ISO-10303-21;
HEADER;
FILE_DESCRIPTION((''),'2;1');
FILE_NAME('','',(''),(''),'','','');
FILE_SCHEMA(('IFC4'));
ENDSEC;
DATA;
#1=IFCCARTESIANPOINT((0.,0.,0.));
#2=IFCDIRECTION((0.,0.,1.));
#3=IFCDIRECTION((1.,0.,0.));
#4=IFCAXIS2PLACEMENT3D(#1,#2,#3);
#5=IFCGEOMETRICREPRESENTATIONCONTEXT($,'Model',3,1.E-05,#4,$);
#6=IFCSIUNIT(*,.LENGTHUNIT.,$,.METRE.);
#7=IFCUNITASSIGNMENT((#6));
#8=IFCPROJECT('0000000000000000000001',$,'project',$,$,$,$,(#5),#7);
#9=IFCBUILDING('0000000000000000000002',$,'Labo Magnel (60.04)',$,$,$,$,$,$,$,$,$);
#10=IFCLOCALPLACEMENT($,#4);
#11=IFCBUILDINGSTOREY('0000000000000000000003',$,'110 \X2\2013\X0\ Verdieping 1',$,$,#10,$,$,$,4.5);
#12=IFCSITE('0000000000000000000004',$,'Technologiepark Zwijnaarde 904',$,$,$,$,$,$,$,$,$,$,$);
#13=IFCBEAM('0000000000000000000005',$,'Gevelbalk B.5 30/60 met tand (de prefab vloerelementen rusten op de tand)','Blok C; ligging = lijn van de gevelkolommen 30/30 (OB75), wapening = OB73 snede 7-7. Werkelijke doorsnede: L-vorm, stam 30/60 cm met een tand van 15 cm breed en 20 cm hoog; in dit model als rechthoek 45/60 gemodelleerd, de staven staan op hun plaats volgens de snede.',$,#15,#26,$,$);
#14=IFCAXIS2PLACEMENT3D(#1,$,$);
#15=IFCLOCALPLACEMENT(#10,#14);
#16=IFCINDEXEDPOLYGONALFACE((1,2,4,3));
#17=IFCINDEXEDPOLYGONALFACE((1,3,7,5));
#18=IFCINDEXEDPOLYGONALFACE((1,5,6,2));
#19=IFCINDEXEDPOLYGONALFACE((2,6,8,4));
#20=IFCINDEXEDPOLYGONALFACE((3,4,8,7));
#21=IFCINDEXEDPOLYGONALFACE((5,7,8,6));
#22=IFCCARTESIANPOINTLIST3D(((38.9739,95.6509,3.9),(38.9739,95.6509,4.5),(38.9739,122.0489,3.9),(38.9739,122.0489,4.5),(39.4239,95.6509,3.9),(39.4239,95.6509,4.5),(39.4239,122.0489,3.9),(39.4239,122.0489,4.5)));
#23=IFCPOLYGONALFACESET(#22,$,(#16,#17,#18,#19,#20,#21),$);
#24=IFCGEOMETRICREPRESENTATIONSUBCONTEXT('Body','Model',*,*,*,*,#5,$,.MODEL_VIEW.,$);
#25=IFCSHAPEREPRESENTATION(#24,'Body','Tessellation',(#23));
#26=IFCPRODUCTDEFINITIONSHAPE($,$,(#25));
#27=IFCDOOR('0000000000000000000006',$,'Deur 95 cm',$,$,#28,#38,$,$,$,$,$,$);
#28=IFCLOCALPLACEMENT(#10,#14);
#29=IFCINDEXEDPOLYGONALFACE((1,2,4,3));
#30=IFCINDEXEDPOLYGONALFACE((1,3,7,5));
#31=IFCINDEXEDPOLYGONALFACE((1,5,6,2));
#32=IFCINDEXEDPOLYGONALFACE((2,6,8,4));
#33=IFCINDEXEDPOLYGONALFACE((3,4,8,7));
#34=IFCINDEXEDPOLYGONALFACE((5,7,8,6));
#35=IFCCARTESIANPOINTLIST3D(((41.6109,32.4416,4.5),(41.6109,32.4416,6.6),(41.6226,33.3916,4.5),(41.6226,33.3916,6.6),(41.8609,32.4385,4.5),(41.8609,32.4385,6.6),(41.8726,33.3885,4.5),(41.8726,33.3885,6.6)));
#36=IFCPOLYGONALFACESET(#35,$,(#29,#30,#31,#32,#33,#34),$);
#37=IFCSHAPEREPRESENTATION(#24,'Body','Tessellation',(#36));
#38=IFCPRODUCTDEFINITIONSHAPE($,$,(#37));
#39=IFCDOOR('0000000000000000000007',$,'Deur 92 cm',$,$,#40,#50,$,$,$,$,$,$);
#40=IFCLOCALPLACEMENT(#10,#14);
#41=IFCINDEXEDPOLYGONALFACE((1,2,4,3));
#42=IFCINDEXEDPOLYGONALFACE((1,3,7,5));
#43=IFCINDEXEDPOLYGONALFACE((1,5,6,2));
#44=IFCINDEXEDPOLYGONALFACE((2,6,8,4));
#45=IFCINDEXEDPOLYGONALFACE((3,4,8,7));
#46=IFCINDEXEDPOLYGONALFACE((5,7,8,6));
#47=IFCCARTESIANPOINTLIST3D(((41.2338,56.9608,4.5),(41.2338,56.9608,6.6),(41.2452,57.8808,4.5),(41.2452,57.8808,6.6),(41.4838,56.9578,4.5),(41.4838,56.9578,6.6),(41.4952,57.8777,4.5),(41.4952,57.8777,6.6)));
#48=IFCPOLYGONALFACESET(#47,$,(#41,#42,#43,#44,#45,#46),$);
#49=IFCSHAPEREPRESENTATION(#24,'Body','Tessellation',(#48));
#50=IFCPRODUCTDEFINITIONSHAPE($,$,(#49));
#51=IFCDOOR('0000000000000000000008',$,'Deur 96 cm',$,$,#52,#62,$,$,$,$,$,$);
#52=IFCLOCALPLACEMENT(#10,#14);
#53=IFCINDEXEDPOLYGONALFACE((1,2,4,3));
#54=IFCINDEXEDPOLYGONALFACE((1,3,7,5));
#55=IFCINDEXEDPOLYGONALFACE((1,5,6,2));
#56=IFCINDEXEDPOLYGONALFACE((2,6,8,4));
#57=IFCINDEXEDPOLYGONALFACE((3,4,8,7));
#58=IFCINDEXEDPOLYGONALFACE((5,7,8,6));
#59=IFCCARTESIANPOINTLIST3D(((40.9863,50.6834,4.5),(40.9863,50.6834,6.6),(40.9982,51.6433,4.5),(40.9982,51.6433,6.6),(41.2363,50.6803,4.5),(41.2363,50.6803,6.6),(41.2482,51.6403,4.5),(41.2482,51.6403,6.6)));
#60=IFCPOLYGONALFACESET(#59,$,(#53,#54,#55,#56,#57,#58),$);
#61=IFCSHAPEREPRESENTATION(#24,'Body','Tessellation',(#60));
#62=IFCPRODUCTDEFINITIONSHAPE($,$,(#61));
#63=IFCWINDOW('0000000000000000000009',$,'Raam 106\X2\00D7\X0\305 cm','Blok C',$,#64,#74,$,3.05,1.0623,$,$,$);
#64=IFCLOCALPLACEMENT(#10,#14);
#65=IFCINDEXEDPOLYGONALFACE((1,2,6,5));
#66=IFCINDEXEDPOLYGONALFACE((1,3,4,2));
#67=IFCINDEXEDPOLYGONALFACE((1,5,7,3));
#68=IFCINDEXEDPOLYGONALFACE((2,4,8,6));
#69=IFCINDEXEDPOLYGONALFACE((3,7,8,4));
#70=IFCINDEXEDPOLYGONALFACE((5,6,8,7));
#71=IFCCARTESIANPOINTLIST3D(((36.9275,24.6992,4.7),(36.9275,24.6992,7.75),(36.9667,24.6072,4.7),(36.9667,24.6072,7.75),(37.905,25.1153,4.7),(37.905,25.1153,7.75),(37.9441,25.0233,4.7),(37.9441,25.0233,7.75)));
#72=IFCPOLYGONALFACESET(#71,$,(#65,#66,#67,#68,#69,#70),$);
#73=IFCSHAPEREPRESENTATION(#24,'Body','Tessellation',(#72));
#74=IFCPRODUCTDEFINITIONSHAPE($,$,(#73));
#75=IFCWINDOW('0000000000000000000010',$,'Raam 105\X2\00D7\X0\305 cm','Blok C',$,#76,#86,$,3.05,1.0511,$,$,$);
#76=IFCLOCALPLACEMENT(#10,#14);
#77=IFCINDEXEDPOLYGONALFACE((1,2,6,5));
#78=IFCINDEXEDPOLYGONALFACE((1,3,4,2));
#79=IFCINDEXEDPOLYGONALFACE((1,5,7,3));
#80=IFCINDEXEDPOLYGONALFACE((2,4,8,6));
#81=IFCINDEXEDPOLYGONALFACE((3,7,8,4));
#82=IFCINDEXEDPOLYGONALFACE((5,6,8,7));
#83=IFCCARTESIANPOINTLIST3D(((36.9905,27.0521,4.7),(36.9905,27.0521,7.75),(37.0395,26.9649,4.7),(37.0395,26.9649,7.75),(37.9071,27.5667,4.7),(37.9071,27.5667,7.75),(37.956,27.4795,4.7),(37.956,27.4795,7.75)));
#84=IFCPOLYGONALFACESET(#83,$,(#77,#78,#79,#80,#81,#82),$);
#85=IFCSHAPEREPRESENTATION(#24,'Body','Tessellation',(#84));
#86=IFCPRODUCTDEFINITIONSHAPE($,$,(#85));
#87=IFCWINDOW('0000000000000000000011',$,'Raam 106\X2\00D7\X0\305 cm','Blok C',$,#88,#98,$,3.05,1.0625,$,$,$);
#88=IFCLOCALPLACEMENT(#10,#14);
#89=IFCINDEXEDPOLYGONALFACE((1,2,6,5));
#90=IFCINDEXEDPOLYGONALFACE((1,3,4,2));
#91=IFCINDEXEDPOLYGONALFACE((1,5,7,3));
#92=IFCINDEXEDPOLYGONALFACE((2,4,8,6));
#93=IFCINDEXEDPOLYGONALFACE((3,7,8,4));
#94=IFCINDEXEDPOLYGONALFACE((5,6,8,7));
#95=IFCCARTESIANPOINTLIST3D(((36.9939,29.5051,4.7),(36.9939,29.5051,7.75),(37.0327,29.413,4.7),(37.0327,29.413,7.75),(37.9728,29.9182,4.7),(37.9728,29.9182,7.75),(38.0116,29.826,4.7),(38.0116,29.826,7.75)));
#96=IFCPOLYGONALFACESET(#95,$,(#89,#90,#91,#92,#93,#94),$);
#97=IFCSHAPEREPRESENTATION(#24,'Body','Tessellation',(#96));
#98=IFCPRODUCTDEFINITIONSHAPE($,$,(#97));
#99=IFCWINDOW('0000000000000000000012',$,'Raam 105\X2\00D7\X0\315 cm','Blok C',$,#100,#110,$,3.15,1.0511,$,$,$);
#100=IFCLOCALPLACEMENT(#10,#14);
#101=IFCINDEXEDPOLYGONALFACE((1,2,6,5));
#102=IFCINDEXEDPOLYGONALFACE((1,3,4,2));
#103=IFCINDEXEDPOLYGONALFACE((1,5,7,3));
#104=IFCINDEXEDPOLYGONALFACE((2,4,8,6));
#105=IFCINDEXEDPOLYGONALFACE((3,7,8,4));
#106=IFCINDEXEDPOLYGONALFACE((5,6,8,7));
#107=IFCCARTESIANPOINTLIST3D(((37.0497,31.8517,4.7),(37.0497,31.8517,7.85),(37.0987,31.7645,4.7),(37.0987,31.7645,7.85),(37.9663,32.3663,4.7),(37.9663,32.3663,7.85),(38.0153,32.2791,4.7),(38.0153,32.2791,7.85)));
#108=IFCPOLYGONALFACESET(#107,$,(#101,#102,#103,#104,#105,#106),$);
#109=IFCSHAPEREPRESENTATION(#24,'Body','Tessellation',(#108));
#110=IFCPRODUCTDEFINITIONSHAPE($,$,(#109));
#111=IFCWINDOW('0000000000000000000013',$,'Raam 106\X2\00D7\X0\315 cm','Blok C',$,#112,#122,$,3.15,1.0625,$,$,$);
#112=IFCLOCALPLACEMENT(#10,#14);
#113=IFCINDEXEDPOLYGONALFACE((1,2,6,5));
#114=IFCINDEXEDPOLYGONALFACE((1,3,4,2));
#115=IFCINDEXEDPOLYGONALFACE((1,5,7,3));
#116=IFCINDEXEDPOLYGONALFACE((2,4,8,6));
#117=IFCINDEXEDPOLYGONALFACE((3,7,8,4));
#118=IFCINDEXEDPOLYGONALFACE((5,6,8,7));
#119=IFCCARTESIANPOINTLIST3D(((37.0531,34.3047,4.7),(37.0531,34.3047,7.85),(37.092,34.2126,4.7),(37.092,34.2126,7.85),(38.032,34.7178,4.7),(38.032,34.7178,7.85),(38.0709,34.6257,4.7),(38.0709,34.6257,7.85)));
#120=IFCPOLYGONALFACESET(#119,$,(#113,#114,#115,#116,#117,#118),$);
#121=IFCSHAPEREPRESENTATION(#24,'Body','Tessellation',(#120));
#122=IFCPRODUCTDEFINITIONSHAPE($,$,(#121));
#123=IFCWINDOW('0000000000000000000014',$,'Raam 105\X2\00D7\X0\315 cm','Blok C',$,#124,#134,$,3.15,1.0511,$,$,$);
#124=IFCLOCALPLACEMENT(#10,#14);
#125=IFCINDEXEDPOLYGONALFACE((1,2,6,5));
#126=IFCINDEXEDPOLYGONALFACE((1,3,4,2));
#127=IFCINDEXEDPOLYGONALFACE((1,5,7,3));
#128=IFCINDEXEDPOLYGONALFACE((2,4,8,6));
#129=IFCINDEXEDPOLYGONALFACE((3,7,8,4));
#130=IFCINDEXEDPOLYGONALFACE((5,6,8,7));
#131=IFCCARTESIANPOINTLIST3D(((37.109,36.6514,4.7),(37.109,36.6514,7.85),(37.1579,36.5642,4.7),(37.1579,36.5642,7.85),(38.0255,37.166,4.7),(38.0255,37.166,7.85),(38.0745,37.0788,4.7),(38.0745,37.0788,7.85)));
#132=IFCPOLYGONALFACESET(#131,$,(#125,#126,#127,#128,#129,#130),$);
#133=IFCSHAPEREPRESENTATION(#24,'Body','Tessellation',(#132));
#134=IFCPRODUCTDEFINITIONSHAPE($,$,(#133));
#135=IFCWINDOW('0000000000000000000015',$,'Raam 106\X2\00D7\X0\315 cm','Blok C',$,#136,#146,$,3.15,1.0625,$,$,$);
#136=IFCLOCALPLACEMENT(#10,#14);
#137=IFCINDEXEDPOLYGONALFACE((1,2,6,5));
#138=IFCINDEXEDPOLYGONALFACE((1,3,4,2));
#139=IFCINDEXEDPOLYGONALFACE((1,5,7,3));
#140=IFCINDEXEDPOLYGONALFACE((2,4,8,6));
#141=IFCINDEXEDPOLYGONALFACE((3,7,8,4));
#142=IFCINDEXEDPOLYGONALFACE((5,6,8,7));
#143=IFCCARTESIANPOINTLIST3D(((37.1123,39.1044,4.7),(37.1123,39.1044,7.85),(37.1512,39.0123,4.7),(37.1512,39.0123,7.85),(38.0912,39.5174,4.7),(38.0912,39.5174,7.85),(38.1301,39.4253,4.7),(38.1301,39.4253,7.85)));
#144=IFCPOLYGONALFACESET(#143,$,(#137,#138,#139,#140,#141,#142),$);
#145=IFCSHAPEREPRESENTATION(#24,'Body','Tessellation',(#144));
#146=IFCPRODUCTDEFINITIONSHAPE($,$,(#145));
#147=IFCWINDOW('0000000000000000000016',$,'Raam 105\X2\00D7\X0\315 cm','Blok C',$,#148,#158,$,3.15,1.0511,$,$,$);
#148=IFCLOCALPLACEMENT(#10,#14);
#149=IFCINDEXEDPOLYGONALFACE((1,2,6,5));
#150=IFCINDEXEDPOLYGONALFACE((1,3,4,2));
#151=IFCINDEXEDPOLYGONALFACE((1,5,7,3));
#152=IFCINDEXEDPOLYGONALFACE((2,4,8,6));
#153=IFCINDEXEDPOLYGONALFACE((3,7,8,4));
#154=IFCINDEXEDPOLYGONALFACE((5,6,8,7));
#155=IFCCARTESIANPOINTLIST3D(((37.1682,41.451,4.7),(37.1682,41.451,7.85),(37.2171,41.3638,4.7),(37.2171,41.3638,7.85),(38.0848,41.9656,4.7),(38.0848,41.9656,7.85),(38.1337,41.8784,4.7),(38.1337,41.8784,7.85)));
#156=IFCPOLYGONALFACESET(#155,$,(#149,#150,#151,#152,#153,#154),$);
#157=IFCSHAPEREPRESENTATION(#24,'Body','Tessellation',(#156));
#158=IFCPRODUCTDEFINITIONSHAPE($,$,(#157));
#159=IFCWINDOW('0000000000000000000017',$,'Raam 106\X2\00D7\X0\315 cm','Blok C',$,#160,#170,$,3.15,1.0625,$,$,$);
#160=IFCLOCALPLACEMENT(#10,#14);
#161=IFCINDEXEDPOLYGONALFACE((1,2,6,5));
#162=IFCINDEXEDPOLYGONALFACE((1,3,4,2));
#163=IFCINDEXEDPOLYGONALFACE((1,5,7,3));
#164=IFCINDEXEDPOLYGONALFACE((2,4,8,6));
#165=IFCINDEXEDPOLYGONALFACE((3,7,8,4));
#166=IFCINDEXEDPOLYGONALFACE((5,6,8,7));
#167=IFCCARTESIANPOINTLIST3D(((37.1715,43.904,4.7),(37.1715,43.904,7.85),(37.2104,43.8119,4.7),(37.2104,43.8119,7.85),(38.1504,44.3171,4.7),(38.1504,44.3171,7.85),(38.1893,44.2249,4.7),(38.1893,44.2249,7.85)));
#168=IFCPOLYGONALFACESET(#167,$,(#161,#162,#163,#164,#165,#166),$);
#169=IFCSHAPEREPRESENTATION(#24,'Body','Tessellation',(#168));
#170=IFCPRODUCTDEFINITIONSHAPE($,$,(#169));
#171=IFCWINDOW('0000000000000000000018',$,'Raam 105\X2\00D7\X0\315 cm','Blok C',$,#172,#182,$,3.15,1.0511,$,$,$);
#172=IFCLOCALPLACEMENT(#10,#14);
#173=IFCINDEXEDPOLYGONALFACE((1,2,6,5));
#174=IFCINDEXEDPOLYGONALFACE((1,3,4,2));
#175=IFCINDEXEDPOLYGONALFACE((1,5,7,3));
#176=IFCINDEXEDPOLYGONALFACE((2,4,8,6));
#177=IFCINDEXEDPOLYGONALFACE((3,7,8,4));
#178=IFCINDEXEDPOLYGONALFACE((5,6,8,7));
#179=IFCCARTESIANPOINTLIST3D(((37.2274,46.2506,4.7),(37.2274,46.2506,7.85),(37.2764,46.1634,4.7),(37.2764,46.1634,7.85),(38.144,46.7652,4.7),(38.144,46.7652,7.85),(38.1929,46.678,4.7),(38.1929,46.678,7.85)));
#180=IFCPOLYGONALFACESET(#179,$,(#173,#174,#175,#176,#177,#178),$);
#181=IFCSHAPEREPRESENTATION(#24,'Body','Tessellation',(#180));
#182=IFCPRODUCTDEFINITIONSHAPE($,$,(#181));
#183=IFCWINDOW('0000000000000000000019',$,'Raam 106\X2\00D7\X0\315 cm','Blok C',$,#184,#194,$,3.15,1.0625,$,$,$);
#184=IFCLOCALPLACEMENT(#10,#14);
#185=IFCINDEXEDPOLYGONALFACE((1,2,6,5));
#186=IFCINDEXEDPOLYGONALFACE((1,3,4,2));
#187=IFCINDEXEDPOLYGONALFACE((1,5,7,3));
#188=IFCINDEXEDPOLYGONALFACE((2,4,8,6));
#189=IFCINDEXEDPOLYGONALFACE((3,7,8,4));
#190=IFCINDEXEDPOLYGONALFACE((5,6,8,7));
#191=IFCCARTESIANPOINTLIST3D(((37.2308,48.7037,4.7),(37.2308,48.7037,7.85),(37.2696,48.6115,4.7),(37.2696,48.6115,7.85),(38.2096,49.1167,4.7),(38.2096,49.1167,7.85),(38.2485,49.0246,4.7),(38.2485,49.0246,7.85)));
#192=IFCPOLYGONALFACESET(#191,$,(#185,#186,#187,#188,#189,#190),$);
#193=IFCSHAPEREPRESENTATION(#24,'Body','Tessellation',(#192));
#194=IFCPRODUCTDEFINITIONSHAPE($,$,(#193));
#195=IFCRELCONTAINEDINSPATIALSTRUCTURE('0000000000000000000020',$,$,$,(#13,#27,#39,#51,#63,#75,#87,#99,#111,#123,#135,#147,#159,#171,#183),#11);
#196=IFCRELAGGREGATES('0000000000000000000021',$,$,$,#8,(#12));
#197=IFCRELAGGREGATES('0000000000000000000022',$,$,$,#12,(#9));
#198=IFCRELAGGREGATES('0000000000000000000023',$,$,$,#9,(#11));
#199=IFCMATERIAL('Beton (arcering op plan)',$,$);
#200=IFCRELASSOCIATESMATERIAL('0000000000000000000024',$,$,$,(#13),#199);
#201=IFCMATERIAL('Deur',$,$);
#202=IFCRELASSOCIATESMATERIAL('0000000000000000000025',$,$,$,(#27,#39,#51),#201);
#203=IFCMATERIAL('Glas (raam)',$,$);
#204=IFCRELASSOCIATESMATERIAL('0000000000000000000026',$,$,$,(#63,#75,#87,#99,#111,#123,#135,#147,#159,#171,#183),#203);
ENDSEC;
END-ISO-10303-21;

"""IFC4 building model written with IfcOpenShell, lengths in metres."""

from ifc_helpers import new_model, si_unit, frame, origin, origin_with_axes, place, context, subcontext, project, spatial, polyline, outline, extrude, material, element, save


model = new_model("IFC4")

# Units and contexts
model_context = context("Model", 3, precision=1e-05, world=origin_with_axes())
body_context = subcontext(model_context, "Body", "Model", "MODEL_VIEW")
ifc_project = project(units=[si_unit("LENGTHUNIT", "METRE")], contexts=[model_context])

# Site, building, storey
site = spatial("IfcSite", under=ifc_project, Name="Technologiepark Zwijnaarde 904")
building = spatial("IfcBuilding", under=site, Name="Labo Magnel (60.04)")
storey_placement = place(None, origin_with_axes())
storey = spatial("IfcBuildingStorey", under=building, at=storey_placement, Name="110 – Verdieping 1", Elevation=4.5)

# Beam
ifc_material_1 = material(Name="Beton (arcering op plan)")
beam_placement = place(storey_placement, frame((0.0, 0.0, 3.9), z_axis=(0.0, 0.0, 1.0), x_axis=(1.0, 0.0, 0.0)))
element("IfcBeam", 1, at=beam_placement, inside=storey, material=ifc_material_1, Name="Gevelbalk B.5 30/60 met tand (de prefab vloerelementen rusten op de tand)", Description="Blok C; ligging = lijn van de gevelkolommen 30/30 (OB75), wapening = OB73 snede 7-7. Werkelijke doorsnede: L-vorm, stam 30/60 cm met een tand van 15 cm breed en 20 cm hoog; in dit model als rechthoek 45/60 gemodelleerd, de staven staan op hun plaats volgens de snede.", context=body_context, shape_type="SweptSolid", body=[
    extrude(outline(polyline([(38.9739, 95.6509), (39.4239, 95.6509), (39.4239, 122.0489), (38.9739, 122.0489), (38.9739, 95.6509)])), origin(), (0.0, 0.0, 1.0), 0.6),
])

# Doors
ifc_material_2 = material(Name="Deur")
door_1_placement = place(storey_placement, frame((41.7359, 32.4401, 4.5), z_axis=(0.0, 0.0, 1.0), x_axis=(0.012338, 0.999924, 0.0)))
element("IfcDoor", 2, at=door_1_placement, inside=storey, material=ifc_material_2, Name="Deur 95 cm", context=body_context, shape_type="SweptSolid", body=[
    extrude(outline(polyline([(0.0, -0.125), (0.95, -0.125), (0.95, 0.125), (0.0, 0.125), (0.0, -0.125)])), origin(), (0.0, 0.0, 1.0), 2.1),
])
door_2_placement = place(storey_placement, frame((41.3588, 56.9593, 4.5), z_axis=(0.0, 0.0, 1.0), x_axis=(0.012338, 0.999924, 0.0)))
element("IfcDoor", 3, at=door_2_placement, inside=storey, material=ifc_material_2, Name="Deur 92 cm", context=body_context, shape_type="SweptSolid", body=[
    extrude(outline(polyline([(0.0, -0.125), (0.92, -0.125), (0.92, 0.125), (0.0, 0.125), (0.0, -0.125)])), origin(), (0.0, 0.0, 1.0), 2.1),
])
door_3_placement = place(storey_placement, frame((41.1232, 51.6418, 4.5), z_axis=(0.0, 0.0, 1.0), x_axis=(-0.012338, -0.999924, 0.0)))
element("IfcDoor", 4, at=door_3_placement, inside=storey, material=ifc_material_2, Name="Deur 96 cm", context=body_context, shape_type="SweptSolid", body=[
    extrude(outline(polyline([(0.0, -0.125), (0.96, -0.125), (0.96, 0.125), (0.0, 0.125), (0.0, -0.125)])), origin(), (0.0, 0.0, 1.0), 2.1),
])

# Windows
ifc_material_3 = material(Name="Glas (raam)")
window_1_placement = place(storey_placement, frame((37.9246, 25.0693, 4.7), z_axis=(0.0, 0.0, 1.0), x_axis=(-0.920114, -0.39165, 0.0)))
element("IfcWindow", 5, at=window_1_placement, inside=storey, material=ifc_material_3, Name="Raam 106×305 cm", Description="Blok C", OverallHeight=3.05, OverallWidth=1.0623, context=body_context, shape_type="SweptSolid", body=[
    extrude(outline(polyline([(0.0, -0.05), (1.0623, -0.05), (1.0623, 0.05), (0.0, 0.05), (0.0, -0.05)])), origin(), (0.0, 0.0, 1.0), 3.05),
])
window_2_placement = place(storey_placement, frame((37.9316, 27.5231, 4.7), z_axis=(0.0, 0.0, 1.0), x_axis=(-0.871972, -0.489555, 0.0)))
element("IfcWindow", 6, at=window_2_placement, inside=storey, material=ifc_material_3, Name="Raam 105×305 cm", Description="Blok C", OverallHeight=3.05, OverallWidth=1.0511, context=body_context, shape_type="SweptSolid", body=[
    extrude(outline(polyline([(0.0, -0.05), (1.0511, -0.05), (1.0511, 0.05), (0.0, 0.05), (0.0, -0.05)])), origin(), (0.0, 0.0, 1.0), 3.05),
])
window_3_placement = place(storey_placement, frame((37.0133, 29.459, 4.7), z_axis=(0.0, 0.0, 1.0), x_axis=(0.92134, 0.388757, 0.0)))
element("IfcWindow", 7, at=window_3_placement, inside=storey, material=ifc_material_3, Name="Raam 106×305 cm", Description="Blok C", OverallHeight=3.05, OverallWidth=1.0625, context=body_context, shape_type="SweptSolid", body=[
    extrude(outline(polyline([(0.0, -0.05), (1.0625, -0.05), (1.0625, 0.05), (0.0, 0.05), (0.0, -0.05)])), origin(), (0.0, 0.0, 1.0), 3.05),
])
window_4_placement = place(storey_placement, frame((37.9908, 32.3227, 4.7), z_axis=(0.0, 0.0, 1.0), x_axis=(-0.871972, -0.489555, 0.0)))
element("IfcWindow", 8, at=window_4_placement, inside=storey, material=ifc_material_3, Name="Raam 105×315 cm", Description="Blok C", OverallHeight=3.15, OverallWidth=1.0511, context=body_context, shape_type="SweptSolid", body=[
    extrude(outline(polyline([(0.0, -0.05), (1.0511, -0.05), (1.0511, 0.05), (0.0, 0.05), (0.0, -0.05)])), origin(), (0.0, 0.0, 1.0), 3.15),
])
window_5_placement = place(storey_placement, frame((37.0725, 34.2587, 4.7), z_axis=(0.0, 0.0, 1.0), x_axis=(0.92134, 0.388757, 0.0)))
element("IfcWindow", 9, at=window_5_placement, inside=storey, material=ifc_material_3, Name="Raam 106×315 cm", Description="Blok C", OverallHeight=3.15, OverallWidth=1.0625, context=body_context, shape_type="SweptSolid", body=[
    extrude(outline(polyline([(0.0, -0.05), (1.0625, -0.05), (1.0625, 0.05), (0.0, 0.05), (0.0, -0.05)])), origin(), (0.0, 0.0, 1.0), 3.15),
])
window_6_placement = place(storey_placement, frame((38.05, 37.1224, 4.7), z_axis=(0.0, 0.0, 1.0), x_axis=(-0.871972, -0.489555, 0.0)))
element("IfcWindow", 10, at=window_6_placement, inside=storey, material=ifc_material_3, Name="Raam 105×315 cm", Description="Blok C", OverallHeight=3.15, OverallWidth=1.0511, context=body_context, shape_type="SweptSolid", body=[
    extrude(outline(polyline([(0.0, -0.05), (1.0511, -0.05), (1.0511, 0.05), (0.0, 0.05), (0.0, -0.05)])), origin(), (0.0, 0.0, 1.0), 3.15),
])
window_7_placement = place(storey_placement, frame((37.1317, 39.0583, 4.7), z_axis=(0.0, 0.0, 1.0), x_axis=(0.92134, 0.388757, 0.0)))
element("IfcWindow", 11, at=window_7_placement, inside=storey, material=ifc_material_3, Name="Raam 106×315 cm", Description="Blok C", OverallHeight=3.15, OverallWidth=1.0625, context=body_context, shape_type="SweptSolid", body=[
    extrude(outline(polyline([(0.0, -0.05), (1.0625, -0.05), (1.0625, 0.05), (0.0, 0.05), (0.0, -0.05)])), origin(), (0.0, 0.0, 1.0), 3.15),
])
window_8_placement = place(storey_placement, frame((38.1092, 41.922, 4.7), z_axis=(0.0, 0.0, 1.0), x_axis=(-0.871972, -0.489555, 0.0)))
element("IfcWindow", 12, at=window_8_placement, inside=storey, material=ifc_material_3, Name="Raam 105×315 cm", Description="Blok C", OverallHeight=3.15, OverallWidth=1.0511, context=body_context, shape_type="SweptSolid", body=[
    extrude(outline(polyline([(0.0, -0.05), (1.0511, -0.05), (1.0511, 0.05), (0.0, 0.05), (0.0, -0.05)])), origin(), (0.0, 0.0, 1.0), 3.15),
])
window_9_placement = place(storey_placement, frame((37.191, 43.858, 4.7), z_axis=(0.0, 0.0, 1.0), x_axis=(0.92134, 0.388757, 0.0)))
element("IfcWindow", 13, at=window_9_placement, inside=storey, material=ifc_material_3, Name="Raam 106×315 cm", Description="Blok C", OverallHeight=3.15, OverallWidth=1.0625, context=body_context, shape_type="SweptSolid", body=[
    extrude(outline(polyline([(0.0, -0.05), (1.0625, -0.05), (1.0625, 0.05), (0.0, 0.05), (0.0, -0.05)])), origin(), (0.0, 0.0, 1.0), 3.15),
])
window_10_placement = place(storey_placement, frame((38.1685, 46.7216, 4.7), z_axis=(0.0, 0.0, 1.0), x_axis=(-0.871972, -0.489555, 0.0)))
element("IfcWindow", 14, at=window_10_placement, inside=storey, material=ifc_material_3, Name="Raam 105×315 cm", Description="Blok C", OverallHeight=3.15, OverallWidth=1.0511, context=body_context, shape_type="SweptSolid", body=[
    extrude(outline(polyline([(0.0, -0.05), (1.0511, -0.05), (1.0511, 0.05), (0.0, 0.05), (0.0, -0.05)])), origin(), (0.0, 0.0, 1.0), 3.15),
])
window_11_placement = place(storey_placement, frame((37.2502, 48.6576, 4.7), z_axis=(0.0, 0.0, 1.0), x_axis=(0.92134, 0.388757, 0.0)))
element("IfcWindow", 15, at=window_11_placement, inside=storey, material=ifc_material_3, Name="Raam 106×315 cm", Description="Blok C", OverallHeight=3.15, OverallWidth=1.0625, context=body_context, shape_type="SweptSolid", body=[
    extrude(outline(polyline([(0.0, -0.05), (1.0625, -0.05), (1.0625, 0.05), (0.0, 0.05), (0.0, -0.05)])), origin(), (0.0, 0.0, 1.0), 3.15),
])

save(model, "model.ifc")
